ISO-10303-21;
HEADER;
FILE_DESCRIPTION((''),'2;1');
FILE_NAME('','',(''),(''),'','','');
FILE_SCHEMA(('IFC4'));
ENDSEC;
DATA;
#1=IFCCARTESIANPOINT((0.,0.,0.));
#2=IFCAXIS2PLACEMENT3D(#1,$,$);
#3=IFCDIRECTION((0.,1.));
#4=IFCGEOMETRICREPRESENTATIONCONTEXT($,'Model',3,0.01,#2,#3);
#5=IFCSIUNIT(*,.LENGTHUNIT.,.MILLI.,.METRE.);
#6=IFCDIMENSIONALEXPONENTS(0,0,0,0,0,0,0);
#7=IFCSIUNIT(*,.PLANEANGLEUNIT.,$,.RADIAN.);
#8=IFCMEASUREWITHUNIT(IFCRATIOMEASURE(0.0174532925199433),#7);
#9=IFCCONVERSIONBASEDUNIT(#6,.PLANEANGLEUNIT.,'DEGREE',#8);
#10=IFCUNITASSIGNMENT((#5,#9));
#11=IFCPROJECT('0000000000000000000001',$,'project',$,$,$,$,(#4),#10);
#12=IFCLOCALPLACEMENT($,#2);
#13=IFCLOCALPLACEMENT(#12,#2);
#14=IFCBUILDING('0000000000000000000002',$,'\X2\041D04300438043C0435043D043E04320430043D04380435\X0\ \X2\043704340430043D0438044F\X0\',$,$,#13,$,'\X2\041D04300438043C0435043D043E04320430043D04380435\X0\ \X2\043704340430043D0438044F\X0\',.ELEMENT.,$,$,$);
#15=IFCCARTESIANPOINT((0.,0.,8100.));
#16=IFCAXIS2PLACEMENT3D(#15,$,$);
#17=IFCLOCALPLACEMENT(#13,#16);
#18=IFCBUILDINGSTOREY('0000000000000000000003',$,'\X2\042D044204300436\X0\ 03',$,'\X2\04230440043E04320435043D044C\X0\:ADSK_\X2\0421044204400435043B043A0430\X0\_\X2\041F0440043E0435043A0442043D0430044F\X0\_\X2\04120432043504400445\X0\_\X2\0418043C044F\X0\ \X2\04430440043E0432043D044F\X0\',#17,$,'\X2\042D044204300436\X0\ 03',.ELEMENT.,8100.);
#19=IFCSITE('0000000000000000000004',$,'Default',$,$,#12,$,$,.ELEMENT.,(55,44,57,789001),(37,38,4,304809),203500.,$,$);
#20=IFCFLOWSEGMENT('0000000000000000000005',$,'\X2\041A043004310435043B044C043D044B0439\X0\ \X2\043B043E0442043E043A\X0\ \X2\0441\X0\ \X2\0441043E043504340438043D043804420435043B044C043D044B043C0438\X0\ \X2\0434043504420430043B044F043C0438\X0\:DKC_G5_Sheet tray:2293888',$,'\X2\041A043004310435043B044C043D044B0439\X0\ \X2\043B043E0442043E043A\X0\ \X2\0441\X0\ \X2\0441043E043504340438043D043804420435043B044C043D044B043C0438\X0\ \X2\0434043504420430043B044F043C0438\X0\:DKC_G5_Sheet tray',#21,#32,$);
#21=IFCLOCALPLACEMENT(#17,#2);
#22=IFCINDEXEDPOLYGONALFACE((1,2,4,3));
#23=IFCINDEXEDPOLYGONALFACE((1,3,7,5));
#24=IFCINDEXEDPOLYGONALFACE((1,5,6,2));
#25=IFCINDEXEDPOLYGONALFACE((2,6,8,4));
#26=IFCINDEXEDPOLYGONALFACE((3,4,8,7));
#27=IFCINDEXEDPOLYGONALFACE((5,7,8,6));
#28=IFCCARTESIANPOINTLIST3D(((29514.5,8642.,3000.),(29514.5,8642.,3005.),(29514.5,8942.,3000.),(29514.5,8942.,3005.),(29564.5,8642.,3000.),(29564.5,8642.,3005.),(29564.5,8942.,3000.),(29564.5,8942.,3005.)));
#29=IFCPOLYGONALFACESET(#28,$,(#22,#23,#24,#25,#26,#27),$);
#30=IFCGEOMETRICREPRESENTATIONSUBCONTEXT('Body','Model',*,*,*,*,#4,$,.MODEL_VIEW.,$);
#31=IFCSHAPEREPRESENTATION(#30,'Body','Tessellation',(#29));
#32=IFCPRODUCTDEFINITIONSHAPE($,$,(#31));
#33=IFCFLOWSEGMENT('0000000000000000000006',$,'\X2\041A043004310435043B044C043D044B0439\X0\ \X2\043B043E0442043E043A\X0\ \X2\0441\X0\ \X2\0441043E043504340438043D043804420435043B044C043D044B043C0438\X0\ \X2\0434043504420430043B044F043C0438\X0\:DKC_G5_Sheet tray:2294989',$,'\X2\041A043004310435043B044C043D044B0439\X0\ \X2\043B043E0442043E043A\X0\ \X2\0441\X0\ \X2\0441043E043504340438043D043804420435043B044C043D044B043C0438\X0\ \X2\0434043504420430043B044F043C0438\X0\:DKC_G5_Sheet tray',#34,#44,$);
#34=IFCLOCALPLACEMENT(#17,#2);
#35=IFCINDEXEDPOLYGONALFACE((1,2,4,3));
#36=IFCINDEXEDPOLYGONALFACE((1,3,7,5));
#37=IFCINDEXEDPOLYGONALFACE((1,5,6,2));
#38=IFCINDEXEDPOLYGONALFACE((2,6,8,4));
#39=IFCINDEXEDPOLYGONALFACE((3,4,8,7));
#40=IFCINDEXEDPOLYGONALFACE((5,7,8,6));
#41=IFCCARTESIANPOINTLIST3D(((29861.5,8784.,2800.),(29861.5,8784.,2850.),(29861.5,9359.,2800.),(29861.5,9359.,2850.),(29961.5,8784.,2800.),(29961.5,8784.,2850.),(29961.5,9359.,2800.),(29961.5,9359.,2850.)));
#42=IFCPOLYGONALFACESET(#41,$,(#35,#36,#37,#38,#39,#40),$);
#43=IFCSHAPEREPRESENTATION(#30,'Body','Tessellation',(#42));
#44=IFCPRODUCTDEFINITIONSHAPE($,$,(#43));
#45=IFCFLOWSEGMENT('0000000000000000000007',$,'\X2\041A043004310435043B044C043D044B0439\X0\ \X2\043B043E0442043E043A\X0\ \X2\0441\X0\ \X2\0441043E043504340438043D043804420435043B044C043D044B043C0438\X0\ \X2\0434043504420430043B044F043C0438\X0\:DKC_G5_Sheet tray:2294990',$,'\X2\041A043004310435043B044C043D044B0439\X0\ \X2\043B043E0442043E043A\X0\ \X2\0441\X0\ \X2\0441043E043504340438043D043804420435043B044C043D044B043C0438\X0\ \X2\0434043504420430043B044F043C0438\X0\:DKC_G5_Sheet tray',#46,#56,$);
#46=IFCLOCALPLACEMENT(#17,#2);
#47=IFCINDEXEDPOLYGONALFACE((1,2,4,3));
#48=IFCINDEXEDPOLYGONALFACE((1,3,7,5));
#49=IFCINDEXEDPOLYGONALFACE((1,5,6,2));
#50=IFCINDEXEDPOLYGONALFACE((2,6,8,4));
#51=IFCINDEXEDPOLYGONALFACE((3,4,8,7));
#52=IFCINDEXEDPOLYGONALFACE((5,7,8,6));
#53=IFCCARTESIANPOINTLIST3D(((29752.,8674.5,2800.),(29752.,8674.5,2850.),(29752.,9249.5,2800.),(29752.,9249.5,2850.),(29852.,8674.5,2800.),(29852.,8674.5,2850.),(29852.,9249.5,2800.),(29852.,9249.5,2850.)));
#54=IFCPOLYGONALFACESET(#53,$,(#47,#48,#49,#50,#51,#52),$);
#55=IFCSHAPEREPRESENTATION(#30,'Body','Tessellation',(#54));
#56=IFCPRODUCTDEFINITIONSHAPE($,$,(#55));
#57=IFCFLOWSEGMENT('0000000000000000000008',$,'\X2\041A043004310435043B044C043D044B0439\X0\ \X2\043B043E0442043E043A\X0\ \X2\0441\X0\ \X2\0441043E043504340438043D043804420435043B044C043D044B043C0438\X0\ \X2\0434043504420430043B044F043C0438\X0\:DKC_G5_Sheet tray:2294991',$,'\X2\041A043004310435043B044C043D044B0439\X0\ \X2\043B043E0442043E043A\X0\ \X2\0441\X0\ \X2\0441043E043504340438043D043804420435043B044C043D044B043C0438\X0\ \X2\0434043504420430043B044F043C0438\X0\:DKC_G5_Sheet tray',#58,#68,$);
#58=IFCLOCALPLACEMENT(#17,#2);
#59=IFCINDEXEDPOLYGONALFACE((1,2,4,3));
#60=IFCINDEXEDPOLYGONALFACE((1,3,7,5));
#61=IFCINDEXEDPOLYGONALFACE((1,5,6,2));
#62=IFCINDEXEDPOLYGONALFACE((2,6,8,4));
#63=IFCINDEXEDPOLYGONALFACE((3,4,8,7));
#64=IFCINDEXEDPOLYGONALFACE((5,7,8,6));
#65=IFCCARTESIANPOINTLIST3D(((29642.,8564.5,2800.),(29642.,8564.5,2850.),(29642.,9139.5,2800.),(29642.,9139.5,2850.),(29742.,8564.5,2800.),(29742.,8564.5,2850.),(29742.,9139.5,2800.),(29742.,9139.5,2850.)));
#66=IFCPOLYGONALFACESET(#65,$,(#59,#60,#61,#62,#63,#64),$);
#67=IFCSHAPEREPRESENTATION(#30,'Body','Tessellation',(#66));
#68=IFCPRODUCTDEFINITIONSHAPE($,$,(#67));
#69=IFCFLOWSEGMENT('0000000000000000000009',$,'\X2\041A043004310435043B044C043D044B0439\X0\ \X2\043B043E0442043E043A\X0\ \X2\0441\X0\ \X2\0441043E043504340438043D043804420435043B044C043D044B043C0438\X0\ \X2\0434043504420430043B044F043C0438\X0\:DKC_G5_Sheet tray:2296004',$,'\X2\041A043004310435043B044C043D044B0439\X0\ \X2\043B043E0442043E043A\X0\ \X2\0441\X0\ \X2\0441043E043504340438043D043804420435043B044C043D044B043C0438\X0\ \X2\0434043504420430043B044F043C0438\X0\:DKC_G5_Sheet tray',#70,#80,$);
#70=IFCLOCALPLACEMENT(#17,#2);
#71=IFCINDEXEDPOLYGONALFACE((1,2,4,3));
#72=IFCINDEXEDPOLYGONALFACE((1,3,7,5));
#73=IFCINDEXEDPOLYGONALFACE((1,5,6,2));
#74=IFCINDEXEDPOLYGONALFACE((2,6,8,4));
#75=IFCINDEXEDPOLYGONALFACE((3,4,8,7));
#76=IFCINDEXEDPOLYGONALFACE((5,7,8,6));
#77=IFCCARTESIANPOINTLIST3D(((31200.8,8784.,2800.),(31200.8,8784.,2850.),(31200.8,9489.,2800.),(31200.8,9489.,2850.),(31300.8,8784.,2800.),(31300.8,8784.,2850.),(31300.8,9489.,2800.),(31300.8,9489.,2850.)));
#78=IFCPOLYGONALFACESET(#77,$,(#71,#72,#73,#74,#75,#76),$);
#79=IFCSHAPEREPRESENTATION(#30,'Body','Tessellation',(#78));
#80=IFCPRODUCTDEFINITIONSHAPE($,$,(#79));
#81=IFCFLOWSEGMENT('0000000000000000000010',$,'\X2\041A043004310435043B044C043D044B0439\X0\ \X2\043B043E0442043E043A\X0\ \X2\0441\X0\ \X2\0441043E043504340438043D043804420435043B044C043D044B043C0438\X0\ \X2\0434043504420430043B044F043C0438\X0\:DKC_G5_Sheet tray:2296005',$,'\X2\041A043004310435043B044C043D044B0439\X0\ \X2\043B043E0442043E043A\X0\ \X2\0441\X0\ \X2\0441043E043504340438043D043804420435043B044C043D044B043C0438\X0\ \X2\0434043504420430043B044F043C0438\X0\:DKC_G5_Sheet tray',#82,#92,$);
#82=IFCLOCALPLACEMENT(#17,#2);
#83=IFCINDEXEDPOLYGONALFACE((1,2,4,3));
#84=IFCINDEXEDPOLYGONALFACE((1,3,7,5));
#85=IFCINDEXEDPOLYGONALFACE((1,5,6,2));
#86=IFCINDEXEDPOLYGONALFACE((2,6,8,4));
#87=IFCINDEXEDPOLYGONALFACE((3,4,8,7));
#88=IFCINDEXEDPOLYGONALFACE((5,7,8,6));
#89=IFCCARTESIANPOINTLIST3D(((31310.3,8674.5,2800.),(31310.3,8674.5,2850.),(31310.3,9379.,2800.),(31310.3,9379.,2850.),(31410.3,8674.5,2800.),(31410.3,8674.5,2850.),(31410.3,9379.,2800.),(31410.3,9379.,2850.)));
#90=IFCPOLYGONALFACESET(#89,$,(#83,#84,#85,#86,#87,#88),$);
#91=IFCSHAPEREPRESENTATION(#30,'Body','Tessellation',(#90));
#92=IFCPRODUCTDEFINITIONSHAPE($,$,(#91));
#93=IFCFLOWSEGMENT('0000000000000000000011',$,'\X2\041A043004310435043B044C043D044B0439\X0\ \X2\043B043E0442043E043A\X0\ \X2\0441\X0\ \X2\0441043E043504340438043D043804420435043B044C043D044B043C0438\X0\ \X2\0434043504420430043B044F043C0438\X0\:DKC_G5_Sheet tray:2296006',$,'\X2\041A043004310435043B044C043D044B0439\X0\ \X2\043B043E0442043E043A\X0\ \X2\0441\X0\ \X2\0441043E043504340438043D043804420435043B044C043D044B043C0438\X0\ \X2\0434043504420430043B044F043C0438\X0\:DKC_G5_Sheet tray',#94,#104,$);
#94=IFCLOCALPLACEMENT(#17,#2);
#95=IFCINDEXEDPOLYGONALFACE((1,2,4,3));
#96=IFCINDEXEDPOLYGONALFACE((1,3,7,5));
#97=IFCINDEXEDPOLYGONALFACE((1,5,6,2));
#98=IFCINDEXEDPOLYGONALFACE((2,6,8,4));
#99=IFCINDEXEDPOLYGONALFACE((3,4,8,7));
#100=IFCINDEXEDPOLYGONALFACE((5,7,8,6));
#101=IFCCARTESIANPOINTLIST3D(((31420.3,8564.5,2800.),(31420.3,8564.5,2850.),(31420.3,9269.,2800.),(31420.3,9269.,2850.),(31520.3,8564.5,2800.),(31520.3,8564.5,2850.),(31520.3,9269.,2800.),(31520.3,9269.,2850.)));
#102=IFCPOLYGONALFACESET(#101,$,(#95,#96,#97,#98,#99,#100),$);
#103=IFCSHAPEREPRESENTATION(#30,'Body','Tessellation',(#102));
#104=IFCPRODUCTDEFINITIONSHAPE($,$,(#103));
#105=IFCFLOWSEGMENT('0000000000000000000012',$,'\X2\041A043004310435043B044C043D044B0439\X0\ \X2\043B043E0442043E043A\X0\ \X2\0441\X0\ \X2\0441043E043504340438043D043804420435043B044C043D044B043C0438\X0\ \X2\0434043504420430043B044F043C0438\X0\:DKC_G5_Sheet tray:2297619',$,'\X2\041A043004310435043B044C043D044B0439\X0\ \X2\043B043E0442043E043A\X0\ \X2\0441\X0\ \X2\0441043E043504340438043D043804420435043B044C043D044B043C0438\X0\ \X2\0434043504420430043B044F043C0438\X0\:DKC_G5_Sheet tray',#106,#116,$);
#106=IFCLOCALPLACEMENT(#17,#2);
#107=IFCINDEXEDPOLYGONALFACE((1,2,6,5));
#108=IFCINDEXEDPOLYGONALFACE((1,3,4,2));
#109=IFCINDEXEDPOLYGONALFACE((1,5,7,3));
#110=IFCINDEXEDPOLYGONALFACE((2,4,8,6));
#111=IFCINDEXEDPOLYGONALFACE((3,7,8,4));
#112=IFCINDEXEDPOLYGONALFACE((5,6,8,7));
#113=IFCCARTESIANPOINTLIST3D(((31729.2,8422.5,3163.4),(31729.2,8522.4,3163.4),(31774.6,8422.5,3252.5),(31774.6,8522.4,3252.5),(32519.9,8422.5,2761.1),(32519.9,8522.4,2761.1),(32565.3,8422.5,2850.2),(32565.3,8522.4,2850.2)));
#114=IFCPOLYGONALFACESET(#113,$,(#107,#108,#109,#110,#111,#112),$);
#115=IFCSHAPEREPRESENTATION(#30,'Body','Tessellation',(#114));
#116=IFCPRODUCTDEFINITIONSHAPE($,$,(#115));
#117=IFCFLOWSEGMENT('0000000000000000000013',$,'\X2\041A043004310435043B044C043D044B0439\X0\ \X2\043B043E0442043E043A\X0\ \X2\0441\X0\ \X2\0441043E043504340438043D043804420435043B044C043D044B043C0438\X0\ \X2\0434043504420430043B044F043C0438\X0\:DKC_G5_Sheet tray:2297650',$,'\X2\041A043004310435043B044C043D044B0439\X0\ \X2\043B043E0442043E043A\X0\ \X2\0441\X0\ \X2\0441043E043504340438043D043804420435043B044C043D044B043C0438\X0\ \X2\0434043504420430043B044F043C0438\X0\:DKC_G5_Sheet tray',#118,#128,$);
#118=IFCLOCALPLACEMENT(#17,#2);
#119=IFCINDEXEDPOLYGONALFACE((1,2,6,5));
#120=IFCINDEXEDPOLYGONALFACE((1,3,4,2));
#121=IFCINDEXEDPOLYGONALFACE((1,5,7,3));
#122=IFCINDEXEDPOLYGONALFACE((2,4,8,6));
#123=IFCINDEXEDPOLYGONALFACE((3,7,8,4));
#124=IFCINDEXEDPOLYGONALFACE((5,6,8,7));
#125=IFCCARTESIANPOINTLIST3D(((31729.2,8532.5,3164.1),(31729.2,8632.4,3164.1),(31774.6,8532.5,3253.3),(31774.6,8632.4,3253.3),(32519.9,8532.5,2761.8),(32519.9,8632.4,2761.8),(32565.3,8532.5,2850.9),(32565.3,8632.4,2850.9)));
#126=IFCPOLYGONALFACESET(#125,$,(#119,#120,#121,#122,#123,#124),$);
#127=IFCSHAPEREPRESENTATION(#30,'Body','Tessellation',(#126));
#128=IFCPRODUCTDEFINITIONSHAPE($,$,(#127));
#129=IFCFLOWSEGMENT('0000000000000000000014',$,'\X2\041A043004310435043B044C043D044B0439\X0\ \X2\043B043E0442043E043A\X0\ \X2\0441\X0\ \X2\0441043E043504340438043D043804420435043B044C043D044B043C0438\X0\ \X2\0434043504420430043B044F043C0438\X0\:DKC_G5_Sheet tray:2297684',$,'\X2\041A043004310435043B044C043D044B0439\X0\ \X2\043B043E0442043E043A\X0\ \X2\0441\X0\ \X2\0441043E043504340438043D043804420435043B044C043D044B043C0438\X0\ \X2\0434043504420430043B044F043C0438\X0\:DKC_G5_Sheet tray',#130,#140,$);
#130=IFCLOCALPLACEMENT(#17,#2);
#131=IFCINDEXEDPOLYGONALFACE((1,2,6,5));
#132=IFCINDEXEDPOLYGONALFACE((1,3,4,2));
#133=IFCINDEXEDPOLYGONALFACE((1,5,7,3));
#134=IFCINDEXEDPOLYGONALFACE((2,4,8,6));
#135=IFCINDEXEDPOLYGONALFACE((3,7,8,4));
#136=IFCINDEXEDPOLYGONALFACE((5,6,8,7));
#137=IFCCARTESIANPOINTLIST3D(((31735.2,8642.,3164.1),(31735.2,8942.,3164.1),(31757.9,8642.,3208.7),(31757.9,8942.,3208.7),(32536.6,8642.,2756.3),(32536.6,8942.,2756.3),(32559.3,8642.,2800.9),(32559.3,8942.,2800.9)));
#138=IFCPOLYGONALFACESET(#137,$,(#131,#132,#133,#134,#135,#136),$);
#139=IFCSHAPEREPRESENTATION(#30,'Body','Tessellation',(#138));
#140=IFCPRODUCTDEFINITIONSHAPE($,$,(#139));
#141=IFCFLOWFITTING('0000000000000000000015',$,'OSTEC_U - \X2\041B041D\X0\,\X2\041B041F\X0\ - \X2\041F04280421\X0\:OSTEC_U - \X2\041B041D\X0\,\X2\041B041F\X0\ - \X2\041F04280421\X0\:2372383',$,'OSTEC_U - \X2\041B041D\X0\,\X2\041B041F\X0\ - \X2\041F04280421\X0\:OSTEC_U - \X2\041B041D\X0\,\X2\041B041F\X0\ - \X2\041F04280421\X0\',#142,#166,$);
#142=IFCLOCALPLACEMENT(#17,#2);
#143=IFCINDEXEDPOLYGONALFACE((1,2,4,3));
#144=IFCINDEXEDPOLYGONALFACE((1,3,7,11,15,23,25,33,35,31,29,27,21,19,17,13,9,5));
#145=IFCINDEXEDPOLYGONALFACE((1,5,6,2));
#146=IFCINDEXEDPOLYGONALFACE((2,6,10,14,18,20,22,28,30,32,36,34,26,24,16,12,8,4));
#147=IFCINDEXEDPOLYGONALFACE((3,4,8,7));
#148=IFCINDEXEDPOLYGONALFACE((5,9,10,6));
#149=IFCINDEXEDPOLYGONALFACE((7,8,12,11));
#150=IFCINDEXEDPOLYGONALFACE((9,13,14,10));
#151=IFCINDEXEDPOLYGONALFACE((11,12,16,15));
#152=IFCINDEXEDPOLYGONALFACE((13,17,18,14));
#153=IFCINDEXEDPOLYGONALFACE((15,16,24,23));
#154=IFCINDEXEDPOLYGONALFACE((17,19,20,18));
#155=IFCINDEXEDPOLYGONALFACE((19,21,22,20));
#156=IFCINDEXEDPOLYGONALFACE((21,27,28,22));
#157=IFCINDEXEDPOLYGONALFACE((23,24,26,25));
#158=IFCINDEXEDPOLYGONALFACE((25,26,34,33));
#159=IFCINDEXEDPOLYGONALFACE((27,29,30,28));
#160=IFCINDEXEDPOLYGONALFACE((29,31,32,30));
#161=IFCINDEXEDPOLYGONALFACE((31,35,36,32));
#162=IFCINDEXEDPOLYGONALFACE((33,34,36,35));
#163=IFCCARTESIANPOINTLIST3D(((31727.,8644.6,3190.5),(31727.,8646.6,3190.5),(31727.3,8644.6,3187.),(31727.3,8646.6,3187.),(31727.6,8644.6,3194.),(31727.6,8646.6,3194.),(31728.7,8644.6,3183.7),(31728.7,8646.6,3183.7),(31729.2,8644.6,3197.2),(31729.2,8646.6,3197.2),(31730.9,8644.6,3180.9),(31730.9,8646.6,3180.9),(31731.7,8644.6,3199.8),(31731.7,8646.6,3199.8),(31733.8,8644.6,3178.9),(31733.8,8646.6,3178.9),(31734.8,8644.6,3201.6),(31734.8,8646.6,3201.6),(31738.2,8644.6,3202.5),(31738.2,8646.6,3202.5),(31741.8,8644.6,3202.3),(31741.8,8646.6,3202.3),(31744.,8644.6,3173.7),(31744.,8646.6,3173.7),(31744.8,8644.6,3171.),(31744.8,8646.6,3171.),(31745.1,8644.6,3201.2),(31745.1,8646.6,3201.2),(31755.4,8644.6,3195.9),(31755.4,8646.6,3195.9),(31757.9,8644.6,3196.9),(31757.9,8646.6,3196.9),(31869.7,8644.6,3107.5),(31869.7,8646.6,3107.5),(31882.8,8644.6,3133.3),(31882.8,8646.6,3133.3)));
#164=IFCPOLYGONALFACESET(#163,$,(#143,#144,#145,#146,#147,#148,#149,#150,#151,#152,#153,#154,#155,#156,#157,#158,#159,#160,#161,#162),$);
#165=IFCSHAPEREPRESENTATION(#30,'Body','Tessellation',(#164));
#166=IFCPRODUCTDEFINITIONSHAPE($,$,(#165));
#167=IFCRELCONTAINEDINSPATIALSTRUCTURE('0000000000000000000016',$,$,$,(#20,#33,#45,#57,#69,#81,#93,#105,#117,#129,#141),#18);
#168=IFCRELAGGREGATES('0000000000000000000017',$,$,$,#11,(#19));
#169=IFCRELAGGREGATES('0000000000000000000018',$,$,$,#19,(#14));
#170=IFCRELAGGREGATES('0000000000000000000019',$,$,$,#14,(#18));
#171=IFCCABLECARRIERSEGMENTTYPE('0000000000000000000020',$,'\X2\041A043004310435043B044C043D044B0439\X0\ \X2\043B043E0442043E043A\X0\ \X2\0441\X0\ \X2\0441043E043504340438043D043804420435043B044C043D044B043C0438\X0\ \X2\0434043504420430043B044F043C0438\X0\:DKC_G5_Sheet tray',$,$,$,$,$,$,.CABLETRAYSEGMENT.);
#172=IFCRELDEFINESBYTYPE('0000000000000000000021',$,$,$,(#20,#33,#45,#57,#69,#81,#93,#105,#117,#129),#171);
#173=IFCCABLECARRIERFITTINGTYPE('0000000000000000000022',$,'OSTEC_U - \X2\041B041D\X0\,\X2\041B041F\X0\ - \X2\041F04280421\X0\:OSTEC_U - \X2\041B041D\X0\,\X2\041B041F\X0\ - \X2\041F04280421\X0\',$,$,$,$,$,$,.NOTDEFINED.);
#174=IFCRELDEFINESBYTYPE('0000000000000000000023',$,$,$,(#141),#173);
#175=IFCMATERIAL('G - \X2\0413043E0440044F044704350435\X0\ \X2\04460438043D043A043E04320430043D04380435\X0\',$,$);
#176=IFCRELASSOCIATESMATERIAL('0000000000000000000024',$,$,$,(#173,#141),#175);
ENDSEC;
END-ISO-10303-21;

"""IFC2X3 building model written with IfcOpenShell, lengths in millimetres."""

from ifc_helpers import new_model, entity, si_unit, converted_unit, direction, frame, frame_2d, origin, origin_2d_with_axis, place, context, subcontext, project, spatial, polyline, circle_curve, parameter, trimmed, segment, composite_curve, rectangle, outline, extrude, source, transform, mapped, material, type_object, type_shapes, element, save


model = new_model("IFC2X3")

# Units and contexts
model_context = context("Model", 3, precision=0.01, world=origin(), true_north=direction((0.0, 1.0)))
body_context = subcontext(model_context, "Body", "Model", "MODEL_VIEW")
ifc_project = project(units=[si_unit("LENGTHUNIT", "METRE", prefix="MILLI"), converted_unit("PLANEANGLEUNIT", "DEGREE", entity("IfcRatioMeasure", 0.0174532925199433), si_unit("PLANEANGLEUNIT", "RADIAN"), dimensions=[0, 0, 0, 0, 0, 0, 0])], contexts=[model_context])

# Site, building, storey
site_placement = place(None, origin())
site = spatial("IfcSite", under=ifc_project, at=site_placement, Name="Default", CompositionType="ELEMENT", RefLatitude=(55, 44, 57, 789001), RefLongitude=(37, 38, 4, 304809), RefElevation=203500.0)
building_placement = place(site_placement, origin())
building = spatial("IfcBuilding", under=site, at=building_placement, Name="Наименование здания", LongName="Наименование здания", CompositionType="ELEMENT")
storey_placement = place(building_placement, frame((0.0, 0.0, 8100.0)))
storey = spatial("IfcBuildingStorey", under=building, at=storey_placement, Name="Этаж 03", ObjectType="Уровень:ADSK_Стрелка_Проектная_Вверх_Имя уровня", LongName="Этаж 03", CompositionType="ELEMENT", Elevation=8100.0)

# Flow segments
cable_carrier_segment_type = type_object("IfcCableCarrierSegmentType", Name="Кабельный лоток с соединительными деталями:DKC_G5_Sheet tray", PredefinedType="CABLETRAYSEGMENT")
flow_segment_1_placement = place(storey_placement, frame((29514.5, 8642.0, 3000.0)))
element("IfcFlowSegment", 1, at=flow_segment_1_placement, inside=storey, type_object=cable_carrier_segment_type, Name="Кабельный лоток с соединительными деталями:DKC_G5_Sheet tray:2293888", ObjectType="Кабельный лоток с соединительными деталями:DKC_G5_Sheet tray", context=body_context, shape_type="SweptSolid", body=[
    extrude(rectangle(XDim=300.0, YDim=50.0, at=origin_2d_with_axis()), frame((25.0, 150.0, 0.0), z_axis=(0.0, 0.0, 1.0), x_axis=(0.0, 1.0, 0.0)), (0.0, 0.0, 1.0), 5.0),
])
flow_segment_2_placement = place(storey_placement, frame((29861.5, 8784.0, 2800.0)))
element("IfcFlowSegment", 2, at=flow_segment_2_placement, inside=storey, type_object=cable_carrier_segment_type, Name="Кабельный лоток с соединительными деталями:DKC_G5_Sheet tray:2294989", ObjectType="Кабельный лоток с соединительными деталями:DKC_G5_Sheet tray", context=body_context, shape_type="SweptSolid", body=[
    extrude(rectangle(XDim=575.0, YDim=100.0, at=origin_2d_with_axis()), frame((50.0, 287.5, 0.0), z_axis=(0.0, 0.0, 1.0), x_axis=(0.0, 1.0, 0.0)), (0.0, 0.0, 1.0), 50.0),
])
flow_segment_3_placement = place(storey_placement, frame((29752.0, 8674.5, 2800.0)))
element("IfcFlowSegment", 3, at=flow_segment_3_placement, inside=storey, type_object=cable_carrier_segment_type, Name="Кабельный лоток с соединительными деталями:DKC_G5_Sheet tray:2294990", ObjectType="Кабельный лоток с соединительными деталями:DKC_G5_Sheet tray", context=body_context, shape_type="SweptSolid", body=[
    extrude(rectangle(XDim=575.0, YDim=100.0, at=origin_2d_with_axis()), frame((50.0, 287.5, 0.0), z_axis=(0.0, 0.0, 1.0), x_axis=(0.0, 1.0, 0.0)), (0.0, 0.0, 1.0), 50.0),
])
flow_segment_4_placement = place(storey_placement, frame((29642.0, 8564.5, 2800.0)))
element("IfcFlowSegment", 4, at=flow_segment_4_placement, inside=storey, type_object=cable_carrier_segment_type, Name="Кабельный лоток с соединительными деталями:DKC_G5_Sheet tray:2294991", ObjectType="Кабельный лоток с соединительными деталями:DKC_G5_Sheet tray", context=body_context, shape_type="SweptSolid", body=[
    extrude(rectangle(XDim=575.0, YDim=100.0, at=origin_2d_with_axis()), frame((50.0, 287.5, 0.0), z_axis=(0.0, 0.0, 1.0), x_axis=(0.0, 1.0, 0.0)), (0.0, 0.0, 1.0), 50.0),
])
flow_segment_5_placement = place(storey_placement, frame((31200.8, 8784.0, 2800.0)))
element("IfcFlowSegment", 5, at=flow_segment_5_placement, inside=storey, type_object=cable_carrier_segment_type, Name="Кабельный лоток с соединительными деталями:DKC_G5_Sheet tray:2296004", ObjectType="Кабельный лоток с соединительными деталями:DKC_G5_Sheet tray", context=body_context, shape_type="SweptSolid", body=[
    extrude(rectangle(XDim=705.0, YDim=100.0, at=origin_2d_with_axis()), frame((50.0, 352.5, 0.0), z_axis=(0.0, 0.0, 1.0), x_axis=(0.0, 1.0, 0.0)), (0.0, 0.0, 1.0), 50.0),
])
flow_segment_6_placement = place(storey_placement, frame((31310.3, 8674.5, 2800.0)))
element("IfcFlowSegment", 6, at=flow_segment_6_placement, inside=storey, type_object=cable_carrier_segment_type, Name="Кабельный лоток с соединительными деталями:DKC_G5_Sheet tray:2296005", ObjectType="Кабельный лоток с соединительными деталями:DKC_G5_Sheet tray", context=body_context, shape_type="SweptSolid", body=[
    extrude(rectangle(XDim=704.5, YDim=100.0, at=origin_2d_with_axis()), frame((50.0, 352.2, 0.0), z_axis=(0.0, 0.0, 1.0), x_axis=(0.0, 1.0, 0.0)), (0.0, 0.0, 1.0), 50.0),
])
flow_segment_7_placement = place(storey_placement, frame((31420.3, 8564.5, 2800.0)))
element("IfcFlowSegment", 7, at=flow_segment_7_placement, inside=storey, type_object=cable_carrier_segment_type, Name="Кабельный лоток с соединительными деталями:DKC_G5_Sheet tray:2296006", ObjectType="Кабельный лоток с соединительными деталями:DKC_G5_Sheet tray", context=body_context, shape_type="SweptSolid", body=[
    extrude(rectangle(XDim=704.5, YDim=100.0, at=origin_2d_with_axis()), frame((50.0, 352.2, 0.0), z_axis=(0.0, 0.0, 1.0), x_axis=(0.0, 1.0, 0.0)), (0.0, 0.0, 1.0), 50.0),
])
flow_segment_8_placement = place(storey_placement, frame((31729.2, 8422.5, 2761.1)))
element("IfcFlowSegment", 8, at=flow_segment_8_placement, inside=storey, type_object=cable_carrier_segment_type, Name="Кабельный лоток с соединительными деталями:DKC_G5_Sheet tray:2297619", ObjectType="Кабельный лоток с соединительными деталями:DKC_G5_Sheet tray", context=body_context, shape_type="SweptSolid", body=[
    extrude(rectangle(XDim=100.0, YDim=100.0, at=origin_2d_with_axis()), frame((22.7, 50.0, 446.9), z_axis=(0.891238, 0.0, -0.453536), x_axis=(0.453536, 0.0, 0.891238)), (0.0, 0.0, 1.0), 887.2),
])
flow_segment_9_placement = place(storey_placement, frame((31729.2, 8532.5, 2761.8)))
element("IfcFlowSegment", 9, at=flow_segment_9_placement, inside=storey, type_object=cable_carrier_segment_type, Name="Кабельный лоток с соединительными деталями:DKC_G5_Sheet tray:2297650", ObjectType="Кабельный лоток с соединительными деталями:DKC_G5_Sheet tray", context=body_context, shape_type="SweptSolid", body=[
    extrude(rectangle(XDim=100.0, YDim=100.0, at=origin_2d_with_axis()), frame((22.7, 50.0, 446.9), z_axis=(0.891243, 0.0, -0.453526), x_axis=(0.453526, 0.0, 0.891243)), (0.0, 0.0, 1.0), 887.2),
])
flow_segment_10_placement = place(storey_placement, frame((31735.2, 8642.0, 2756.3)))
element("IfcFlowSegment", 10, at=flow_segment_10_placement, inside=storey, type_object=cable_carrier_segment_type, Name="Кабельный лоток с соединительными деталями:DKC_G5_Sheet tray:2297684", ObjectType="Кабельный лоток с соединительными деталями:DKC_G5_Sheet tray", context=body_context, shape_type="SweptSolid", body=[
    extrude(rectangle(XDim=50.0, YDim=300.0, at=origin_2d_with_axis()), frame((11.3, 150.0, 430.1), z_axis=(0.891246, 0.0, -0.453521), x_axis=(0.453521, 0.0, 0.891246)), (0.0, 0.0, 1.0), 899.2),
])

# Flow fitting
ifc_material_1 = material(Name="G - Горячее цинкование")
cable_carrier_fitting_type_1 = type_object("IfcCableCarrierFittingType", Name="OSTEC_U - ЛН,ЛП - ПШС:OSTEC_U - ЛН,ЛП - ПШС", PredefinedType="NOTDEFINED", material=ifc_material_1)
shared_shape_1 = source(origin(), body_context, "Body", "SweptSolid", [
    extrude(outline(composite_curve([segment(trimmed(circle_curve(frame_2d((-44.6, 0.0), x_axis=(1.0, 0.0)), 12.5), [parameter(90.0)], [parameter(270.0)], True, "PARAMETER"), True, "CONTINUOUS"), segment(polyline([(-44.6, -12.5), (-33.1, -12.5)]), True, "CONTINUOUS"), segment(polyline([(-33.1, -12.5), (-31.2, -14.5)]), True, "CONTINUOUS"), segment(polyline([(-31.2, -14.5), (108.9, -14.5)]), True, "CONTINUOUS"), segment(polyline([(108.9, -14.5), (108.9, 14.5)]), True, "CONTINUOUS"), segment(polyline([(108.9, 14.5), (-31.2, 14.5)]), True, "CONTINUOUS"), segment(polyline([(-31.2, 14.5), (-33.1, 12.5)]), True, "CONTINUOUS"), segment(polyline([(-33.1, 12.5), (-44.6, 12.5)]), True, "CONTINUOUS")], self_intersect=False)), frame((44.6, 0.0, 0.0)), (0.0, 0.0, 1.0), 2.0),
])
type_shapes(cable_carrier_fitting_type_1, [shared_shape_1])
flow_fitting_1_placement = place(storey_placement, frame((31739.5, 8646.6, 3190.0), z_axis=(0.0, -1.0, 0.0), x_axis=(0.891246, 0.0, -0.453521)))
element("IfcFlowFitting", 11, at=flow_fitting_1_placement, inside=storey, type_object=cable_carrier_fitting_type_1, material=ifc_material_1, Name="OSTEC_U - ЛН,ЛП - ПШС:OSTEC_U - ЛН,ЛП - ПШС:2372383", ObjectType="OSTEC_U - ЛН,ЛП - ПШС:OSTEC_U - ЛН,ЛП - ПШС", context=body_context, shape_type="MappedRepresentation", body=[
    mapped(shared_shape_1, transform((0.0, 0.0, 0.0), scale=1.0)),
])

save(model, "model.ifc")
